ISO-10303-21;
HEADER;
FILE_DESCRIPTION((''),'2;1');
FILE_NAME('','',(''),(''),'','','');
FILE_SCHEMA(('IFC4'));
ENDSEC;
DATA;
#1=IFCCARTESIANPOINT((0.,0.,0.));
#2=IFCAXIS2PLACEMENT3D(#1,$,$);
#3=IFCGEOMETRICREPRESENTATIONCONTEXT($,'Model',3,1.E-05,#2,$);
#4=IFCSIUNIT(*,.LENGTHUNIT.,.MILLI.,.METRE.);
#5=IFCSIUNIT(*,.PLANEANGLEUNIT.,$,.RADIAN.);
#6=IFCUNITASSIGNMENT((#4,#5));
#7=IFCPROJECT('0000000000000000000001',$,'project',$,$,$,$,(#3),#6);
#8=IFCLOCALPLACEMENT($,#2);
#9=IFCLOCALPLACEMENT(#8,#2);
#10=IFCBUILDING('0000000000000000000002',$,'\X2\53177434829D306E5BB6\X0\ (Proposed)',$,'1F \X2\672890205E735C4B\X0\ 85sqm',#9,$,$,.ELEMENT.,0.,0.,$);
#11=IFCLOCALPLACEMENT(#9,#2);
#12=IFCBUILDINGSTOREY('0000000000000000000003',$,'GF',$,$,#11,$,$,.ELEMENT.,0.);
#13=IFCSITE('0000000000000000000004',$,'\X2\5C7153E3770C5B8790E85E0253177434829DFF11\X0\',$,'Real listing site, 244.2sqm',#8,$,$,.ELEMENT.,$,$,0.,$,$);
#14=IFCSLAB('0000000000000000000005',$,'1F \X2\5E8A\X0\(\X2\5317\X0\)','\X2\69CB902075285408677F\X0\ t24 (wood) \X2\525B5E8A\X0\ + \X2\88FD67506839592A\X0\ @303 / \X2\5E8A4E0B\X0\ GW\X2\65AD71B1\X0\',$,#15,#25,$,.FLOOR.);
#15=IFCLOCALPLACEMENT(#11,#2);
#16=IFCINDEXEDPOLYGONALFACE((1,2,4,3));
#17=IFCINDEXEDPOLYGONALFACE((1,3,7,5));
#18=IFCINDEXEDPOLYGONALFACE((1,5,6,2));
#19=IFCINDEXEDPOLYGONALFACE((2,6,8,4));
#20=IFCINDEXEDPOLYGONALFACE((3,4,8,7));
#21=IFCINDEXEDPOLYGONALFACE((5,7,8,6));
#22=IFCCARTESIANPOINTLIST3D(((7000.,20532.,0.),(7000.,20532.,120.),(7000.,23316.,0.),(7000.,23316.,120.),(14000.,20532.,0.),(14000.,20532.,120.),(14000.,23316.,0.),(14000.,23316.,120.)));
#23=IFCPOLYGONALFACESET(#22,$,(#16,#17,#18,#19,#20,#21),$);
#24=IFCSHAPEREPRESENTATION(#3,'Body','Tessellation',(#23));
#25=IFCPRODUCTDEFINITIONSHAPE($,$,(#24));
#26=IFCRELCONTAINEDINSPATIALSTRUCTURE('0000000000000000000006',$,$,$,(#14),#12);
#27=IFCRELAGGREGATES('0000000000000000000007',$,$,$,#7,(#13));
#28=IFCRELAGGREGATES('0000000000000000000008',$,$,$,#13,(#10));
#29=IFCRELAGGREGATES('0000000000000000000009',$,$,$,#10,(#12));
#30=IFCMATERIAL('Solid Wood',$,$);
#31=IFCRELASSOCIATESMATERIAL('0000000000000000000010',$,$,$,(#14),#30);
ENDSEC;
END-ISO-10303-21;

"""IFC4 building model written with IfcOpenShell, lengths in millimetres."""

from ifc_helpers import new_model, si_unit, frame, frame_2d, origin, place, context, project, spatial, rectangle, extrude, material, element, save


model = new_model("IFC4")

# Units and contexts
model_context = context("Model", 3, precision=1e-05, world=origin())
ifc_project = project(units=[si_unit("LENGTHUNIT", "METRE", prefix="MILLI"), si_unit("PLANEANGLEUNIT", "RADIAN")], contexts=[model_context])

# Site, building, storey
site_placement = place(None, origin())
site = spatial("IfcSite", under=ifc_project, at=site_placement, Name="山口県宇部市北琴芝１", ObjectType="Real listing site, 244.2sqm", CompositionType="ELEMENT", RefElevation=0.0)
building_placement = place(site_placement, origin())
building = spatial("IfcBuilding", under=site, at=building_placement, Name="北琴芝の家 (Proposed)", ObjectType="1F 木造平屋 85sqm", CompositionType="ELEMENT", ElevationOfRefHeight=0.0, ElevationOfTerrain=0.0)
storey_placement = place(building_placement, origin())
storey = spatial("IfcBuildingStorey", under=building, at=storey_placement, Name="GF", CompositionType="ELEMENT", Elevation=0.0)

# Slab
ifc_material_1 = material(Name="Solid Wood")
slab_1_placement = place(storey_placement, frame((3500.0, 10266.0, 0.0)))
element("IfcSlab", 1, at=slab_1_placement, inside=storey, material=ifc_material_1, Name="1F 床(北)", Description="構造用合板 t24 (wood) 剛床 + 製材根太 @303 / 床下 GW断熱", PredefinedType="FLOOR", context=model_context, shape_type="SweptSolid", body=[
    extrude(rectangle(XDim=7000.0, YDim=2784.0, at=frame_2d((3500.0, 1392.0))), frame((3500.0, 10266.0, 0.0)), (0.0, 0.0, 1.0), 120.0),
])

save(model, "model.ifc")
